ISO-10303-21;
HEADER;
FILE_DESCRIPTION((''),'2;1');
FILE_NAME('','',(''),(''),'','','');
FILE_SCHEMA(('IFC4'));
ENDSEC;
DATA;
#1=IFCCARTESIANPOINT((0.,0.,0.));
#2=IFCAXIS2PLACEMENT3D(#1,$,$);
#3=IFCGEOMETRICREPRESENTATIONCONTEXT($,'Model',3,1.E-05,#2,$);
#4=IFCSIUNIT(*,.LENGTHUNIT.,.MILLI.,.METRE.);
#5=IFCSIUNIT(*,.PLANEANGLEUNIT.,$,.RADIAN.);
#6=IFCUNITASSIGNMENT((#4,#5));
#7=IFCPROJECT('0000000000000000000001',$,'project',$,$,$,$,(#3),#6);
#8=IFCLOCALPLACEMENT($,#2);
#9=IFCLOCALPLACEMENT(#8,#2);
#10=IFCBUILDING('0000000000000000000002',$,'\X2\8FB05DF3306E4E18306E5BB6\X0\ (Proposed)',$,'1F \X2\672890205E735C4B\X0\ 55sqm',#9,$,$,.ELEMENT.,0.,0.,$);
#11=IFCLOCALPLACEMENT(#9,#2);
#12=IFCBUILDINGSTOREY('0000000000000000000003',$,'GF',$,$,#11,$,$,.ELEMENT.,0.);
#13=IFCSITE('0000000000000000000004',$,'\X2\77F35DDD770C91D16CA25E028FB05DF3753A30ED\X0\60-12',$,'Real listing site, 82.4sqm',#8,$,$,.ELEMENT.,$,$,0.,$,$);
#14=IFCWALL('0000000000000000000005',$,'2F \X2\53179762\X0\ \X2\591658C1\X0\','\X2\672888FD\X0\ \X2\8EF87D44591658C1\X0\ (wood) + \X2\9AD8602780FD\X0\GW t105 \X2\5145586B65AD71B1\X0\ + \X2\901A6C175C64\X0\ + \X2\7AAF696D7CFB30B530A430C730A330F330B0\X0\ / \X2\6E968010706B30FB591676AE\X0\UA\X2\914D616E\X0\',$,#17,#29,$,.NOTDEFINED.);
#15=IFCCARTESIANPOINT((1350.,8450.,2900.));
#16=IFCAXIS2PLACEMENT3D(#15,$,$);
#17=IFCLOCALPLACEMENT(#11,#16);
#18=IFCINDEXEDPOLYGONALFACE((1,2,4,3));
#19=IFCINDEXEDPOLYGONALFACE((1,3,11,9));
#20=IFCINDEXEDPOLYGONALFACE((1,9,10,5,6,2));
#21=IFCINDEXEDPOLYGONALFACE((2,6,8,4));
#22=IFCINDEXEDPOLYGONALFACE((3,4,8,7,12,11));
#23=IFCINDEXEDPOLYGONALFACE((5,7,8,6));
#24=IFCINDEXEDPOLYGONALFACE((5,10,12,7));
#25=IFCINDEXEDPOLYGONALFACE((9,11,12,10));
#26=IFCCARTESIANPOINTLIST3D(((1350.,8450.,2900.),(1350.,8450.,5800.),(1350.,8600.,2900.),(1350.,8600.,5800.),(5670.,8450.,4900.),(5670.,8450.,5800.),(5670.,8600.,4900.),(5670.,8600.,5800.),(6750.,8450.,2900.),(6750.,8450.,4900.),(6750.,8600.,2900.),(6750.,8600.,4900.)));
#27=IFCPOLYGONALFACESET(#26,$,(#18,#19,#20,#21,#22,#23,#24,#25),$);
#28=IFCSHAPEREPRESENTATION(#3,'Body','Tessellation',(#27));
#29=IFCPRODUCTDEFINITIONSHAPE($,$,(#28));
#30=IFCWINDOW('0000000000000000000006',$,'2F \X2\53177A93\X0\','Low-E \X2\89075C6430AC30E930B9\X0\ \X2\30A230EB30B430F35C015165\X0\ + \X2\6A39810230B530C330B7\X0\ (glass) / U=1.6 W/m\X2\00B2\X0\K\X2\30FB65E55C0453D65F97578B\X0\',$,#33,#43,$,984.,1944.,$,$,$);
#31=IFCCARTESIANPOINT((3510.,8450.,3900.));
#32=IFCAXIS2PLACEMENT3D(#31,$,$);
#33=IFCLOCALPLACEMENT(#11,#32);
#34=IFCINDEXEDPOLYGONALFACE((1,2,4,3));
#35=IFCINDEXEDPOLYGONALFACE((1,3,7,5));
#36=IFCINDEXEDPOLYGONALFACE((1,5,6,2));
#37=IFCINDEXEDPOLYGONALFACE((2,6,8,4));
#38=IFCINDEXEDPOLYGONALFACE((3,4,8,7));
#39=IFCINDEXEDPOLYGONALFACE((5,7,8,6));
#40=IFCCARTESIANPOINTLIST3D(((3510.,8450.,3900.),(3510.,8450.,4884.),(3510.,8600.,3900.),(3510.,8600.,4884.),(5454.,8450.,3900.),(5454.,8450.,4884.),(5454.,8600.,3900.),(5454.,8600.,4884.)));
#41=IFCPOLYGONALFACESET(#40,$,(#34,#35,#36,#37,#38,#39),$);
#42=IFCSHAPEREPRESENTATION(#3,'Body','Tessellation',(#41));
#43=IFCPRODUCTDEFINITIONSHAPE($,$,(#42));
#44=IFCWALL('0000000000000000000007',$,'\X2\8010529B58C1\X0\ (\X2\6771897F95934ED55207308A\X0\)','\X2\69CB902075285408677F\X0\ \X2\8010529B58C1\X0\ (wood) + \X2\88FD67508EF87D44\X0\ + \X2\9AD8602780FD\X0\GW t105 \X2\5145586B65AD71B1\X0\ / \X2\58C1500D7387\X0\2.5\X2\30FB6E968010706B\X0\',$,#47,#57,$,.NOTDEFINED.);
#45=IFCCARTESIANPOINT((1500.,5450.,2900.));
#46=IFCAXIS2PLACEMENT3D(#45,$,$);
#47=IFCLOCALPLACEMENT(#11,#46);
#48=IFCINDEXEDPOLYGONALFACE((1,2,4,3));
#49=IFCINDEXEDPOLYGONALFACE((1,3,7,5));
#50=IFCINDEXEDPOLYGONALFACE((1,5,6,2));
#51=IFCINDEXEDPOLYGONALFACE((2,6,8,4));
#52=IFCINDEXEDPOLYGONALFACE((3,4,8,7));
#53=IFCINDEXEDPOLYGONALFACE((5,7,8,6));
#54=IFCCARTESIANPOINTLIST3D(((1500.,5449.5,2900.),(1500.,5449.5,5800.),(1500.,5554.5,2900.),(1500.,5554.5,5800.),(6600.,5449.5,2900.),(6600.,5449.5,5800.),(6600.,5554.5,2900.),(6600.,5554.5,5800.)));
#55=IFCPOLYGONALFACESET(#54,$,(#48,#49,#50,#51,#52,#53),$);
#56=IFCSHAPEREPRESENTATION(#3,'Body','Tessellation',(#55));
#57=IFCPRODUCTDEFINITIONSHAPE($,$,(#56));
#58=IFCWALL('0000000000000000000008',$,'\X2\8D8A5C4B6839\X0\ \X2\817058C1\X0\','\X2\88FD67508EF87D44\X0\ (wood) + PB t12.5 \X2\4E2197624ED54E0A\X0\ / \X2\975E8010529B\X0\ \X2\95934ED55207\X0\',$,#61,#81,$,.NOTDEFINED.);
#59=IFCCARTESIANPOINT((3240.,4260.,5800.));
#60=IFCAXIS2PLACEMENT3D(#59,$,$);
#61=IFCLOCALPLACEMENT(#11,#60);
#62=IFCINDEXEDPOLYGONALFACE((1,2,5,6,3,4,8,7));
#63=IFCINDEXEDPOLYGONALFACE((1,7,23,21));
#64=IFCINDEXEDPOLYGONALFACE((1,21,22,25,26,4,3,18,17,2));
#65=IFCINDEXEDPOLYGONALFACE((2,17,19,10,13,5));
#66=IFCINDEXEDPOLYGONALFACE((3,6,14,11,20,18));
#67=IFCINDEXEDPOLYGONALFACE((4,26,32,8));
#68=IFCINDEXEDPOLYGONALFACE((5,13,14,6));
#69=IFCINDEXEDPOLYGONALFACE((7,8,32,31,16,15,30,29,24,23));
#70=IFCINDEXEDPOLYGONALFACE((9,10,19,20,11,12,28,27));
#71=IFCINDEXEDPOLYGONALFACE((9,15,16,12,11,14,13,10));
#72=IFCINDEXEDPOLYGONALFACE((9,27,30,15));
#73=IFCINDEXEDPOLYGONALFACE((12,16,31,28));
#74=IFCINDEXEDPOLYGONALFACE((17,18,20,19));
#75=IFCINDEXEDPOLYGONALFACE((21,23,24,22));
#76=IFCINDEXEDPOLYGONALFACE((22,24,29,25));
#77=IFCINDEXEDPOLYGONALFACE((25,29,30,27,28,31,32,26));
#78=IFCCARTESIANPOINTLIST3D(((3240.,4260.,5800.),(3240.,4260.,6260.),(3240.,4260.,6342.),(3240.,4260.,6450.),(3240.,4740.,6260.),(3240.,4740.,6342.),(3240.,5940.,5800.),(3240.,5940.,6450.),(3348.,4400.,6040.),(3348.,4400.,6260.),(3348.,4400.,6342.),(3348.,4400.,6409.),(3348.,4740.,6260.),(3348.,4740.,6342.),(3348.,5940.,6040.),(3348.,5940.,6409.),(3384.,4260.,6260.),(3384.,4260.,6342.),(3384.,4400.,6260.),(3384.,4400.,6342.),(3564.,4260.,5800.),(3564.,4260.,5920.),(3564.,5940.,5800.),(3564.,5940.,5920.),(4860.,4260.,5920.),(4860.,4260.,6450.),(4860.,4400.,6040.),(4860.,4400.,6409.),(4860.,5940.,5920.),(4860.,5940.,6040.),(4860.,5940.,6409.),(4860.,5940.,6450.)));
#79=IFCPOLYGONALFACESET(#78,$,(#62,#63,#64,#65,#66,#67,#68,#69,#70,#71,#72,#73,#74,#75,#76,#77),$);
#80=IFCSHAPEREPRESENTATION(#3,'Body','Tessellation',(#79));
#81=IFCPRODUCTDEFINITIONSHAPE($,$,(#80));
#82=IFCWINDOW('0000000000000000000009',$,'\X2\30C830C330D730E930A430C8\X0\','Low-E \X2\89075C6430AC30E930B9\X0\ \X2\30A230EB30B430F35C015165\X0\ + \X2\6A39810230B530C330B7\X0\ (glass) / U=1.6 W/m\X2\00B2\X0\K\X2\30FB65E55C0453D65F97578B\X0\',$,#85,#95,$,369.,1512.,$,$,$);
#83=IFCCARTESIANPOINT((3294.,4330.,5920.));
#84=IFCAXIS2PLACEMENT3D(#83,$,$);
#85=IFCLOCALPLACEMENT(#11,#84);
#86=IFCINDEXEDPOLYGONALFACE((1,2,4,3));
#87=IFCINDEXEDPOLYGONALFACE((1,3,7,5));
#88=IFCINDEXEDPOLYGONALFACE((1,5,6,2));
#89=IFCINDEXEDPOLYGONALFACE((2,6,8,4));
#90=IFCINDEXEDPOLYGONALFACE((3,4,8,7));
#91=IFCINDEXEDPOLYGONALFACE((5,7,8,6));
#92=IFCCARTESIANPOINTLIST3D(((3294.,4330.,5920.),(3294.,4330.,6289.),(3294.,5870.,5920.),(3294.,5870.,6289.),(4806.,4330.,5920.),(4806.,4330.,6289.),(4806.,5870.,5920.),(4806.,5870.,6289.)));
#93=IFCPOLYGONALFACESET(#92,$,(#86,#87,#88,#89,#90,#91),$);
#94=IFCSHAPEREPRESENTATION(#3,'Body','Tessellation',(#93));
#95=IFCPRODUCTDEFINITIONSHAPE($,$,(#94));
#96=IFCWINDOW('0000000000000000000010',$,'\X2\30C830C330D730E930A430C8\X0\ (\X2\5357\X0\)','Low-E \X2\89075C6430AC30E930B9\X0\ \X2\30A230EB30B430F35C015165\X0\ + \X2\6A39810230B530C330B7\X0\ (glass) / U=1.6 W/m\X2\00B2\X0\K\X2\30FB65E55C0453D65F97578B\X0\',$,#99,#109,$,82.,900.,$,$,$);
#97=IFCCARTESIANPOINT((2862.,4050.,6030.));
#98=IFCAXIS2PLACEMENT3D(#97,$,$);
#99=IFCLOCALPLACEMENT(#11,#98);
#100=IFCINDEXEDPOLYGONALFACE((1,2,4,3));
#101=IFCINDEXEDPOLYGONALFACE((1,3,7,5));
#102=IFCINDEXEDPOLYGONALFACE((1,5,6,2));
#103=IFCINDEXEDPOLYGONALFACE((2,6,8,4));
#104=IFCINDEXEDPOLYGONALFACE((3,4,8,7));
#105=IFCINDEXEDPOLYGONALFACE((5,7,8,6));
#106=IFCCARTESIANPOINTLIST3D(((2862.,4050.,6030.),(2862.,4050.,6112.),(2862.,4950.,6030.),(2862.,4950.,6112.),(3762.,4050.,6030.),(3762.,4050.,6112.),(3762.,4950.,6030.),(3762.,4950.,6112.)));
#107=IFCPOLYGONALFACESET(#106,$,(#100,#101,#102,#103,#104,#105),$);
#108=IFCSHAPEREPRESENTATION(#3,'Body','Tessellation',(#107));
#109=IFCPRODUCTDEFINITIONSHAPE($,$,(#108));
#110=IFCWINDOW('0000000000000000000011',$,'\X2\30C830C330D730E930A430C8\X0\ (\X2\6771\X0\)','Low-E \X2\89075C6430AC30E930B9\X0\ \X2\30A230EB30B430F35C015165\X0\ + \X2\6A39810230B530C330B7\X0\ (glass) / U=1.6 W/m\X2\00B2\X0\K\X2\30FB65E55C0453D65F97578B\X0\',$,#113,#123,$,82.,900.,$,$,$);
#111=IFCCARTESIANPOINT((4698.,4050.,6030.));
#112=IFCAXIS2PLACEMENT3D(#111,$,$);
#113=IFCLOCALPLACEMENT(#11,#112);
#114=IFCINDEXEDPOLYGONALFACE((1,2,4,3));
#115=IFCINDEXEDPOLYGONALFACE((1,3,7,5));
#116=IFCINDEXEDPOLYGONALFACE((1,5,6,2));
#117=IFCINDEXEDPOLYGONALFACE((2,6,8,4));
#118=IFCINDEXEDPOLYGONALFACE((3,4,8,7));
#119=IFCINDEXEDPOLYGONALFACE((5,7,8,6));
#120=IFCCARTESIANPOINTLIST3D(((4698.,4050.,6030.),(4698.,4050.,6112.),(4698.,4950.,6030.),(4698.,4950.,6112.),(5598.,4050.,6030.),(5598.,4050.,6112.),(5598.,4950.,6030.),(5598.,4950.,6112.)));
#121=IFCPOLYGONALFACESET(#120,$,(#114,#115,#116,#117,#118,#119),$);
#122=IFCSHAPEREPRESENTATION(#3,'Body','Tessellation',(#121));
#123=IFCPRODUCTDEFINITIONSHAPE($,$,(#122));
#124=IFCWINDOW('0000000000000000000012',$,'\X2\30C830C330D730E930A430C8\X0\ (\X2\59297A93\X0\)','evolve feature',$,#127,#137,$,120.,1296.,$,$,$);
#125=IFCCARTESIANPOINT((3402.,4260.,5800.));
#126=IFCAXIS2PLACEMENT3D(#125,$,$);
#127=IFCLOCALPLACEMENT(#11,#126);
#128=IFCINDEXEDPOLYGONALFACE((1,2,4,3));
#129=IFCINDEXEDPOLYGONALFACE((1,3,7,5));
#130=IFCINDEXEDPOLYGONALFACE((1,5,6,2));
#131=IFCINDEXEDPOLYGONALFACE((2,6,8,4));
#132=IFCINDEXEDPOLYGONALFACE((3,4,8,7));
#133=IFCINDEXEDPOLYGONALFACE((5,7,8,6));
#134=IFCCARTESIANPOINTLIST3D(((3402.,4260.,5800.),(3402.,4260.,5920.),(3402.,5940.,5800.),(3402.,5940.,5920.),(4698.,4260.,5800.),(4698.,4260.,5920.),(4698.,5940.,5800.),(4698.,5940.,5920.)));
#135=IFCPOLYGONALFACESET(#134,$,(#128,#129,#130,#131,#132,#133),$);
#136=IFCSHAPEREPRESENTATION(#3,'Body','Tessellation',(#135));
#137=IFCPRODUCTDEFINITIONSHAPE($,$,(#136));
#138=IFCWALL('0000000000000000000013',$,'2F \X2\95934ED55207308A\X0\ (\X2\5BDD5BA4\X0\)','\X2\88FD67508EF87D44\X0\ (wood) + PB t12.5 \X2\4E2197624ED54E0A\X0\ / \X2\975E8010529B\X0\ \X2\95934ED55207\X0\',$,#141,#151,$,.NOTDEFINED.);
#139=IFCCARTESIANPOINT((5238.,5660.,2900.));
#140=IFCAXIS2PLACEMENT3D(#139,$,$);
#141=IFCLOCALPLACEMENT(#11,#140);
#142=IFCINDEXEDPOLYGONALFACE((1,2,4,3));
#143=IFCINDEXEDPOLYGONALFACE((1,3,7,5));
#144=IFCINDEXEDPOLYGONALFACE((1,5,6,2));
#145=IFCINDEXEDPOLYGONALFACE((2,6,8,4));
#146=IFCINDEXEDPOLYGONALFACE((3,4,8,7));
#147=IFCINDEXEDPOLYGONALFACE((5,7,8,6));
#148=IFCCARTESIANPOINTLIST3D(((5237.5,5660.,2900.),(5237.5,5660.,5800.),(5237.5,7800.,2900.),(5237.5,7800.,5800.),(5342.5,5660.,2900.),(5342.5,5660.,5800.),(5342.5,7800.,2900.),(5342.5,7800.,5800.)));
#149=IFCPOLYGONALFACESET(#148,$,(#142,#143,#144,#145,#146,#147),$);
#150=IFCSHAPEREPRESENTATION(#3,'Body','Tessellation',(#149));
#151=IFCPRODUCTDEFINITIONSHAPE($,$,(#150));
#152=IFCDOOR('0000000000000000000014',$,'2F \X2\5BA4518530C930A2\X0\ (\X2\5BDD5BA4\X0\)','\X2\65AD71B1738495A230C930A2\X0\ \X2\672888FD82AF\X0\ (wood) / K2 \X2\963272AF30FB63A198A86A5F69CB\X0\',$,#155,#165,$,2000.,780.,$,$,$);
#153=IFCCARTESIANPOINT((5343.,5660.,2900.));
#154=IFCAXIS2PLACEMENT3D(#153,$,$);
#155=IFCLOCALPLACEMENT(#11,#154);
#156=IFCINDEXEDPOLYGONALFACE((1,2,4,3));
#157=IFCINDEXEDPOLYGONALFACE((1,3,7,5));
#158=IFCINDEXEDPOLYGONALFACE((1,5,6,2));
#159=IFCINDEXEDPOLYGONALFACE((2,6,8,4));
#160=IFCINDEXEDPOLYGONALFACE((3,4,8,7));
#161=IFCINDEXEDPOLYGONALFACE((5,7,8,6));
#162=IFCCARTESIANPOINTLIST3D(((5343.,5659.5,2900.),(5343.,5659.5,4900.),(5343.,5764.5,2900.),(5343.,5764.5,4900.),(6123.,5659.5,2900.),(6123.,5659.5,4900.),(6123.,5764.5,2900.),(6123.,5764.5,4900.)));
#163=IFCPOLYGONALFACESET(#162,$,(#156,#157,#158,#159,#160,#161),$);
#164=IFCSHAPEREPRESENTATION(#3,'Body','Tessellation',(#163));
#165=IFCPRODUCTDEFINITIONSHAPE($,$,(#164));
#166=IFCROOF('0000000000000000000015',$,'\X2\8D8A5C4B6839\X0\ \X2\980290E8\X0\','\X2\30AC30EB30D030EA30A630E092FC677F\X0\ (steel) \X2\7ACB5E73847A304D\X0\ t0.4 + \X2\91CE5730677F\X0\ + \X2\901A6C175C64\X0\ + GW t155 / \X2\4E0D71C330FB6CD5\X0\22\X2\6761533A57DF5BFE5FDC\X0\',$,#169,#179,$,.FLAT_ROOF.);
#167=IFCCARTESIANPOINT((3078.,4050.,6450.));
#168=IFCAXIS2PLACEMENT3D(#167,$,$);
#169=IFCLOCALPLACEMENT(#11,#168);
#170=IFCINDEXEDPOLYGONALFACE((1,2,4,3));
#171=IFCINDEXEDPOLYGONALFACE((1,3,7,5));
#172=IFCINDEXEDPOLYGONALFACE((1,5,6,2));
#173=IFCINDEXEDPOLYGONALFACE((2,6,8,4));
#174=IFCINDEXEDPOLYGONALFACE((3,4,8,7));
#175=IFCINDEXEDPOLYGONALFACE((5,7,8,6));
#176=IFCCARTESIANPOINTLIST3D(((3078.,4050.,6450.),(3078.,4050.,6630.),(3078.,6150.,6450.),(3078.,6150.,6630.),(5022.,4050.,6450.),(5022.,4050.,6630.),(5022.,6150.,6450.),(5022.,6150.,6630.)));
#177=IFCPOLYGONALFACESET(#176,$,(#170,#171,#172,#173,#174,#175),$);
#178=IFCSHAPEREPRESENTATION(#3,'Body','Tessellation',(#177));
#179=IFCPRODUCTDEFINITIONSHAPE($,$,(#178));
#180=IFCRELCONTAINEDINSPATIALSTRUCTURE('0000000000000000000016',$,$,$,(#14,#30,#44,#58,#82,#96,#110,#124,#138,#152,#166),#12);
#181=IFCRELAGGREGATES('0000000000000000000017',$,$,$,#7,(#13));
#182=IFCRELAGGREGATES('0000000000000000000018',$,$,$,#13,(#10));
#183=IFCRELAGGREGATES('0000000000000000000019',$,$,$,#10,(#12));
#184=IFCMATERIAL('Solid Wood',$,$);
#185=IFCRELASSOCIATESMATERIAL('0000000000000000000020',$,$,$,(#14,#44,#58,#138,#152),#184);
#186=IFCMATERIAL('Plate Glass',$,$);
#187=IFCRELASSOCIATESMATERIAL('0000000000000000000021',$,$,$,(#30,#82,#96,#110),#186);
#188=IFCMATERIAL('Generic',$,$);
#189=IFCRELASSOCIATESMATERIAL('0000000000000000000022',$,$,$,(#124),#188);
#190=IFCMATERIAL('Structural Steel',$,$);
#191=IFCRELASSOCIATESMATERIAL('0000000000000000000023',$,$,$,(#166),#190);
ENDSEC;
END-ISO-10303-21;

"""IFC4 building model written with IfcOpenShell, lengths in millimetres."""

from ifc_helpers import new_model, si_unit, frame, frame_2d, origin, place, context, project, spatial, rectangle, extrude, material, element, fill, save


model = new_model("IFC4")

# Units and contexts
model_context = context("Model", 3, precision=1e-05, world=origin())
ifc_project = project(units=[si_unit("LENGTHUNIT", "METRE", prefix="MILLI"), si_unit("PLANEANGLEUNIT", "RADIAN")], contexts=[model_context])

# Site, building, storey
site_placement = place(None, origin())
site = spatial("IfcSite", under=ifc_project, at=site_placement, Name="石川県金沢市辰巳町ロ60-12", ObjectType="Real listing site, 82.4sqm", CompositionType="ELEMENT", RefElevation=0.0)
building_placement = place(site_placement, origin())
building = spatial("IfcBuilding", under=site, at=building_placement, Name="辰巳の丘の家 (Proposed)", ObjectType="1F 木造平屋 55sqm", CompositionType="ELEMENT", ElevationOfRefHeight=0.0, ElevationOfTerrain=0.0)
storey_placement = place(building_placement, origin())
storey = spatial("IfcBuildingStorey", under=building, at=storey_placement, Name="GF", CompositionType="ELEMENT", Elevation=0.0)

# Wall, opening, window
ifc_material_1 = material(Name="Solid Wood")
wall_1_placement = place(storey_placement, frame((1350.0, 8450.0, 2900.0)))
wall_1 = element("IfcWall", 1, at=wall_1_placement, inside=storey, material=ifc_material_1, Name="2F 北面 外壁", Description="木製 軸組外壁 (wood) + 高性能GW t105 充填断熱 + 通気層 + 窯業系サイディング / 準耐火・外皮UA配慮", PredefinedType="NOTDEFINED", context=model_context, shape_type="SweptSolid", body=[
    extrude(rectangle(XDim=5400.0, YDim=150.0, at=frame_2d((2700.0, 75.0))), frame((1350.0, 8450.0, 2900.0)), (0.0, 0.0, 1.0), 2900.0),
])
opening_1_placement = place(storey_placement, frame((3510.0, 8450.0, 3900.0)))
opening_1 = element("IfcOpeningElement", 2, at=opening_1_placement, cuts=wall_1, PredefinedType="NOTDEFINED", context=model_context, shape_type="SweptSolid", body=[
    extrude(rectangle(XDim=1944.0, YDim=150.0, at=frame_2d((972.0, 75.0))), frame((3510.0, 8450.0, 3900.0)), (0.0, 0.0, 1.0), 984.0),
])
ifc_material_2 = material(Name="Plate Glass")
window_1_placement = place(storey_placement, frame((3510.0, 8450.0, 3900.0)))
window_1 = element("IfcWindow", 3, at=window_1_placement, inside=storey, material=ifc_material_2, Name="2F 北窓", Description="Low-E 複層ガラス アルゴン封入 + 樹脂サッシ (glass) / U=1.6 W/m²K・日射取得型", OverallHeight=984.0, OverallWidth=1944.0, context=model_context, shape_type="SweptSolid", body=[
    extrude(rectangle(XDim=1944.0, YDim=150.0, at=frame_2d((972.0, 75.0))), frame((3510.0, 8450.0, 3900.0)), (0.0, 0.0, 1.0), 984.0),
])
fill(opening_1, window_1)

# Wall
wall_2_placement = place(storey_placement, frame((1500.0, 5450.0, 2900.0)))
element("IfcWall", 4, at=wall_2_placement, inside=storey, material=ifc_material_1, Name="耐力壁 (東西間仕切り)", Description="構造用合板 耐力壁 (wood) + 製材軸組 + 高性能GW t105 充填断熱 / 壁倍率2.5・準耐火", PredefinedType="NOTDEFINED", context=model_context, shape_type="SweptSolid", body=[
    extrude(rectangle(XDim=5100.0, YDim=105.0, at=frame_2d((2550.0, 52.0))), frame((1500.0, 5450.0, 2900.0)), (0.0, 0.0, 1.0), 2900.0),
])

# Wall, openings, windows
wall_3_placement = place(storey_placement, frame((3240.0, 4260.0, 5800.0)))
wall_3 = element("IfcWall", 5, at=wall_3_placement, inside=storey, material=ifc_material_1, Name="越屋根 腰壁", Description="製材軸組 (wood) + PB t12.5 両面仕上 / 非耐力 間仕切", PredefinedType="NOTDEFINED", context=model_context, shape_type="SweptSolid", body=[
    extrude(rectangle(XDim=1620.0, YDim=1680.0, at=frame_2d((810.0, 840.0))), frame((3240.0, 4260.0, 5800.0)), (0.0, 0.0, 1.0), 650.0),
])
opening_2_placement = place(storey_placement, frame((3294.0, 4330.0, 5920.0)))
opening_2 = element("IfcOpeningElement", 6, at=opening_2_placement, cuts=wall_3, PredefinedType="NOTDEFINED", context=model_context, shape_type="SweptSolid", body=[
    extrude(rectangle(XDim=1512.0, YDim=1540.0, at=frame_2d((756.0, 770.0))), frame((3294.0, 4330.0, 5920.0)), (0.0, 0.0, 1.0), 369.0),
])
opening_3_placement = place(storey_placement, frame((2862.0, 4050.0, 6030.0)))
opening_3 = element("IfcOpeningElement", 7, at=opening_3_placement, cuts=wall_3, PredefinedType="NOTDEFINED", context=model_context, shape_type="SweptSolid", body=[
    extrude(rectangle(XDim=900.0, YDim=900.0, at=frame_2d((450.0, 450.0))), frame((2862.0, 4050.0, 6030.0)), (0.0, 0.0, 1.0), 82.0),
])
opening_4_placement = place(storey_placement, frame((4698.0, 4050.0, 6030.0)))
opening_4 = element("IfcOpeningElement", 8, at=opening_4_placement, cuts=wall_3, PredefinedType="NOTDEFINED", context=model_context, shape_type="SweptSolid", body=[
    extrude(rectangle(XDim=900.0, YDim=900.0, at=frame_2d((450.0, 450.0))), frame((4698.0, 4050.0, 6030.0)), (0.0, 0.0, 1.0), 82.0),
])
opening_5_placement = place(storey_placement, frame((3402.0, 4260.0, 5800.0)))
opening_5 = element("IfcOpeningElement", 9, at=opening_5_placement, cuts=wall_3, PredefinedType="NOTDEFINED", context=model_context, shape_type="SweptSolid", body=[
    extrude(rectangle(XDim=1296.0, YDim=1680.0, at=frame_2d((648.0, 840.0))), frame((3402.0, 4260.0, 5800.0)), (0.0, 0.0, 1.0), 120.0),
])
window_2_placement = place(storey_placement, frame((3294.0, 4330.0, 5920.0)))
window_2 = element("IfcWindow", 10, at=window_2_placement, inside=storey, material=ifc_material_2, Name="トップライト", Description="Low-E 複層ガラス アルゴン封入 + 樹脂サッシ (glass) / U=1.6 W/m²K・日射取得型", OverallHeight=369.0, OverallWidth=1512.0, context=model_context, shape_type="SweptSolid", body=[
    extrude(rectangle(XDim=1512.0, YDim=1540.0, at=frame_2d((756.0, 770.0))), frame((3294.0, 4330.0, 5920.0)), (0.0, 0.0, 1.0), 369.0),
])
fill(opening_2, window_2)
window_3_placement = place(storey_placement, frame((2862.0, 4050.0, 6030.0)))
window_3 = element("IfcWindow", 11, at=window_3_placement, inside=storey, material=ifc_material_2, Name="トップライト (南)", Description="Low-E 複層ガラス アルゴン封入 + 樹脂サッシ (glass) / U=1.6 W/m²K・日射取得型", OverallHeight=82.0, OverallWidth=900.0, context=model_context, shape_type="SweptSolid", body=[
    extrude(rectangle(XDim=900.0, YDim=900.0, at=frame_2d((450.0, 450.0))), frame((2862.0, 4050.0, 6030.0)), (0.0, 0.0, 1.0), 82.0),
])
fill(opening_3, window_3)
window_4_placement = place(storey_placement, frame((4698.0, 4050.0, 6030.0)))
window_4 = element("IfcWindow", 12, at=window_4_placement, inside=storey, material=ifc_material_2, Name="トップライト (東)", Description="Low-E 複層ガラス アルゴン封入 + 樹脂サッシ (glass) / U=1.6 W/m²K・日射取得型", OverallHeight=82.0, OverallWidth=900.0, context=model_context, shape_type="SweptSolid", body=[
    extrude(rectangle(XDim=900.0, YDim=900.0, at=frame_2d((450.0, 450.0))), frame((4698.0, 4050.0, 6030.0)), (0.0, 0.0, 1.0), 82.0),
])
fill(opening_4, window_4)
ifc_material_3 = material(Name="Generic")
window_5_placement = place(storey_placement, frame((3402.0, 4260.0, 5800.0)))
window_5 = element("IfcWindow", 13, at=window_5_placement, inside=storey, material=ifc_material_3, Name="トップライト (天窓)", Description="evolve feature", OverallHeight=120.0, OverallWidth=1296.0, context=model_context, shape_type="SweptSolid", body=[
    extrude(rectangle(XDim=1296.0, YDim=1680.0, at=frame_2d((648.0, 840.0))), frame((3402.0, 4260.0, 5800.0)), (0.0, 0.0, 1.0), 120.0),
])
fill(opening_5, window_5)

# Wall
wall_4_placement = place(storey_placement, frame((5238.0, 5660.0, 2900.0)))
element("IfcWall", 14, at=wall_4_placement, inside=storey, material=ifc_material_1, Name="2F 間仕切り (寝室)", Description="製材軸組 (wood) + PB t12.5 両面仕上 / 非耐力 間仕切", PredefinedType="NOTDEFINED", context=model_context, shape_type="SweptSolid", body=[
    extrude(rectangle(XDim=105.0, YDim=2140.0, at=frame_2d((52.0, 1070.0))), frame((5238.0, 5660.0, 2900.0)), (0.0, 0.0, 1.0), 2900.0),
])

# Door
door_placement = place(storey_placement, frame((5343.0, 5660.0, 2900.0)))
element("IfcDoor", 15, at=door_placement, inside=storey, material=ifc_material_1, Name="2F 室内ドア (寝室)", Description="断熱玄関ドア 木製芯 (wood) / K2 防犯・採風機構", OverallHeight=2000.0, OverallWidth=780.0, context=model_context, shape_type="SweptSolid", body=[
    extrude(rectangle(XDim=780.0, YDim=105.0, at=frame_2d((390.0, 52.0))), frame((5343.0, 5660.0, 2900.0)), (0.0, 0.0, 1.0), 2000.0),
])

# Roof
ifc_material_4 = material(Name="Structural Steel")
roof_placement = place(storey_placement, frame((3078.0, 4050.0, 6450.0)))
element("IfcRoof", 16, at=roof_placement, inside=storey, material=ifc_material_4, Name="越屋根 頂部", Description="ガルバリウム鋼板 (steel) 立平葺き t0.4 + 野地板 + 通気層 + GW t155 / 不燃・法22条区域対応", PredefinedType="FLAT_ROOF", context=model_context, shape_type="SweptSolid", body=[
    extrude(rectangle(XDim=1944.0, YDim=2100.0, at=frame_2d((972.0, 1050.0))), frame((3078.0, 4050.0, 6450.0)), (0.0, 0.0, 1.0), 180.0),
])

save(model, "model.ifc")
